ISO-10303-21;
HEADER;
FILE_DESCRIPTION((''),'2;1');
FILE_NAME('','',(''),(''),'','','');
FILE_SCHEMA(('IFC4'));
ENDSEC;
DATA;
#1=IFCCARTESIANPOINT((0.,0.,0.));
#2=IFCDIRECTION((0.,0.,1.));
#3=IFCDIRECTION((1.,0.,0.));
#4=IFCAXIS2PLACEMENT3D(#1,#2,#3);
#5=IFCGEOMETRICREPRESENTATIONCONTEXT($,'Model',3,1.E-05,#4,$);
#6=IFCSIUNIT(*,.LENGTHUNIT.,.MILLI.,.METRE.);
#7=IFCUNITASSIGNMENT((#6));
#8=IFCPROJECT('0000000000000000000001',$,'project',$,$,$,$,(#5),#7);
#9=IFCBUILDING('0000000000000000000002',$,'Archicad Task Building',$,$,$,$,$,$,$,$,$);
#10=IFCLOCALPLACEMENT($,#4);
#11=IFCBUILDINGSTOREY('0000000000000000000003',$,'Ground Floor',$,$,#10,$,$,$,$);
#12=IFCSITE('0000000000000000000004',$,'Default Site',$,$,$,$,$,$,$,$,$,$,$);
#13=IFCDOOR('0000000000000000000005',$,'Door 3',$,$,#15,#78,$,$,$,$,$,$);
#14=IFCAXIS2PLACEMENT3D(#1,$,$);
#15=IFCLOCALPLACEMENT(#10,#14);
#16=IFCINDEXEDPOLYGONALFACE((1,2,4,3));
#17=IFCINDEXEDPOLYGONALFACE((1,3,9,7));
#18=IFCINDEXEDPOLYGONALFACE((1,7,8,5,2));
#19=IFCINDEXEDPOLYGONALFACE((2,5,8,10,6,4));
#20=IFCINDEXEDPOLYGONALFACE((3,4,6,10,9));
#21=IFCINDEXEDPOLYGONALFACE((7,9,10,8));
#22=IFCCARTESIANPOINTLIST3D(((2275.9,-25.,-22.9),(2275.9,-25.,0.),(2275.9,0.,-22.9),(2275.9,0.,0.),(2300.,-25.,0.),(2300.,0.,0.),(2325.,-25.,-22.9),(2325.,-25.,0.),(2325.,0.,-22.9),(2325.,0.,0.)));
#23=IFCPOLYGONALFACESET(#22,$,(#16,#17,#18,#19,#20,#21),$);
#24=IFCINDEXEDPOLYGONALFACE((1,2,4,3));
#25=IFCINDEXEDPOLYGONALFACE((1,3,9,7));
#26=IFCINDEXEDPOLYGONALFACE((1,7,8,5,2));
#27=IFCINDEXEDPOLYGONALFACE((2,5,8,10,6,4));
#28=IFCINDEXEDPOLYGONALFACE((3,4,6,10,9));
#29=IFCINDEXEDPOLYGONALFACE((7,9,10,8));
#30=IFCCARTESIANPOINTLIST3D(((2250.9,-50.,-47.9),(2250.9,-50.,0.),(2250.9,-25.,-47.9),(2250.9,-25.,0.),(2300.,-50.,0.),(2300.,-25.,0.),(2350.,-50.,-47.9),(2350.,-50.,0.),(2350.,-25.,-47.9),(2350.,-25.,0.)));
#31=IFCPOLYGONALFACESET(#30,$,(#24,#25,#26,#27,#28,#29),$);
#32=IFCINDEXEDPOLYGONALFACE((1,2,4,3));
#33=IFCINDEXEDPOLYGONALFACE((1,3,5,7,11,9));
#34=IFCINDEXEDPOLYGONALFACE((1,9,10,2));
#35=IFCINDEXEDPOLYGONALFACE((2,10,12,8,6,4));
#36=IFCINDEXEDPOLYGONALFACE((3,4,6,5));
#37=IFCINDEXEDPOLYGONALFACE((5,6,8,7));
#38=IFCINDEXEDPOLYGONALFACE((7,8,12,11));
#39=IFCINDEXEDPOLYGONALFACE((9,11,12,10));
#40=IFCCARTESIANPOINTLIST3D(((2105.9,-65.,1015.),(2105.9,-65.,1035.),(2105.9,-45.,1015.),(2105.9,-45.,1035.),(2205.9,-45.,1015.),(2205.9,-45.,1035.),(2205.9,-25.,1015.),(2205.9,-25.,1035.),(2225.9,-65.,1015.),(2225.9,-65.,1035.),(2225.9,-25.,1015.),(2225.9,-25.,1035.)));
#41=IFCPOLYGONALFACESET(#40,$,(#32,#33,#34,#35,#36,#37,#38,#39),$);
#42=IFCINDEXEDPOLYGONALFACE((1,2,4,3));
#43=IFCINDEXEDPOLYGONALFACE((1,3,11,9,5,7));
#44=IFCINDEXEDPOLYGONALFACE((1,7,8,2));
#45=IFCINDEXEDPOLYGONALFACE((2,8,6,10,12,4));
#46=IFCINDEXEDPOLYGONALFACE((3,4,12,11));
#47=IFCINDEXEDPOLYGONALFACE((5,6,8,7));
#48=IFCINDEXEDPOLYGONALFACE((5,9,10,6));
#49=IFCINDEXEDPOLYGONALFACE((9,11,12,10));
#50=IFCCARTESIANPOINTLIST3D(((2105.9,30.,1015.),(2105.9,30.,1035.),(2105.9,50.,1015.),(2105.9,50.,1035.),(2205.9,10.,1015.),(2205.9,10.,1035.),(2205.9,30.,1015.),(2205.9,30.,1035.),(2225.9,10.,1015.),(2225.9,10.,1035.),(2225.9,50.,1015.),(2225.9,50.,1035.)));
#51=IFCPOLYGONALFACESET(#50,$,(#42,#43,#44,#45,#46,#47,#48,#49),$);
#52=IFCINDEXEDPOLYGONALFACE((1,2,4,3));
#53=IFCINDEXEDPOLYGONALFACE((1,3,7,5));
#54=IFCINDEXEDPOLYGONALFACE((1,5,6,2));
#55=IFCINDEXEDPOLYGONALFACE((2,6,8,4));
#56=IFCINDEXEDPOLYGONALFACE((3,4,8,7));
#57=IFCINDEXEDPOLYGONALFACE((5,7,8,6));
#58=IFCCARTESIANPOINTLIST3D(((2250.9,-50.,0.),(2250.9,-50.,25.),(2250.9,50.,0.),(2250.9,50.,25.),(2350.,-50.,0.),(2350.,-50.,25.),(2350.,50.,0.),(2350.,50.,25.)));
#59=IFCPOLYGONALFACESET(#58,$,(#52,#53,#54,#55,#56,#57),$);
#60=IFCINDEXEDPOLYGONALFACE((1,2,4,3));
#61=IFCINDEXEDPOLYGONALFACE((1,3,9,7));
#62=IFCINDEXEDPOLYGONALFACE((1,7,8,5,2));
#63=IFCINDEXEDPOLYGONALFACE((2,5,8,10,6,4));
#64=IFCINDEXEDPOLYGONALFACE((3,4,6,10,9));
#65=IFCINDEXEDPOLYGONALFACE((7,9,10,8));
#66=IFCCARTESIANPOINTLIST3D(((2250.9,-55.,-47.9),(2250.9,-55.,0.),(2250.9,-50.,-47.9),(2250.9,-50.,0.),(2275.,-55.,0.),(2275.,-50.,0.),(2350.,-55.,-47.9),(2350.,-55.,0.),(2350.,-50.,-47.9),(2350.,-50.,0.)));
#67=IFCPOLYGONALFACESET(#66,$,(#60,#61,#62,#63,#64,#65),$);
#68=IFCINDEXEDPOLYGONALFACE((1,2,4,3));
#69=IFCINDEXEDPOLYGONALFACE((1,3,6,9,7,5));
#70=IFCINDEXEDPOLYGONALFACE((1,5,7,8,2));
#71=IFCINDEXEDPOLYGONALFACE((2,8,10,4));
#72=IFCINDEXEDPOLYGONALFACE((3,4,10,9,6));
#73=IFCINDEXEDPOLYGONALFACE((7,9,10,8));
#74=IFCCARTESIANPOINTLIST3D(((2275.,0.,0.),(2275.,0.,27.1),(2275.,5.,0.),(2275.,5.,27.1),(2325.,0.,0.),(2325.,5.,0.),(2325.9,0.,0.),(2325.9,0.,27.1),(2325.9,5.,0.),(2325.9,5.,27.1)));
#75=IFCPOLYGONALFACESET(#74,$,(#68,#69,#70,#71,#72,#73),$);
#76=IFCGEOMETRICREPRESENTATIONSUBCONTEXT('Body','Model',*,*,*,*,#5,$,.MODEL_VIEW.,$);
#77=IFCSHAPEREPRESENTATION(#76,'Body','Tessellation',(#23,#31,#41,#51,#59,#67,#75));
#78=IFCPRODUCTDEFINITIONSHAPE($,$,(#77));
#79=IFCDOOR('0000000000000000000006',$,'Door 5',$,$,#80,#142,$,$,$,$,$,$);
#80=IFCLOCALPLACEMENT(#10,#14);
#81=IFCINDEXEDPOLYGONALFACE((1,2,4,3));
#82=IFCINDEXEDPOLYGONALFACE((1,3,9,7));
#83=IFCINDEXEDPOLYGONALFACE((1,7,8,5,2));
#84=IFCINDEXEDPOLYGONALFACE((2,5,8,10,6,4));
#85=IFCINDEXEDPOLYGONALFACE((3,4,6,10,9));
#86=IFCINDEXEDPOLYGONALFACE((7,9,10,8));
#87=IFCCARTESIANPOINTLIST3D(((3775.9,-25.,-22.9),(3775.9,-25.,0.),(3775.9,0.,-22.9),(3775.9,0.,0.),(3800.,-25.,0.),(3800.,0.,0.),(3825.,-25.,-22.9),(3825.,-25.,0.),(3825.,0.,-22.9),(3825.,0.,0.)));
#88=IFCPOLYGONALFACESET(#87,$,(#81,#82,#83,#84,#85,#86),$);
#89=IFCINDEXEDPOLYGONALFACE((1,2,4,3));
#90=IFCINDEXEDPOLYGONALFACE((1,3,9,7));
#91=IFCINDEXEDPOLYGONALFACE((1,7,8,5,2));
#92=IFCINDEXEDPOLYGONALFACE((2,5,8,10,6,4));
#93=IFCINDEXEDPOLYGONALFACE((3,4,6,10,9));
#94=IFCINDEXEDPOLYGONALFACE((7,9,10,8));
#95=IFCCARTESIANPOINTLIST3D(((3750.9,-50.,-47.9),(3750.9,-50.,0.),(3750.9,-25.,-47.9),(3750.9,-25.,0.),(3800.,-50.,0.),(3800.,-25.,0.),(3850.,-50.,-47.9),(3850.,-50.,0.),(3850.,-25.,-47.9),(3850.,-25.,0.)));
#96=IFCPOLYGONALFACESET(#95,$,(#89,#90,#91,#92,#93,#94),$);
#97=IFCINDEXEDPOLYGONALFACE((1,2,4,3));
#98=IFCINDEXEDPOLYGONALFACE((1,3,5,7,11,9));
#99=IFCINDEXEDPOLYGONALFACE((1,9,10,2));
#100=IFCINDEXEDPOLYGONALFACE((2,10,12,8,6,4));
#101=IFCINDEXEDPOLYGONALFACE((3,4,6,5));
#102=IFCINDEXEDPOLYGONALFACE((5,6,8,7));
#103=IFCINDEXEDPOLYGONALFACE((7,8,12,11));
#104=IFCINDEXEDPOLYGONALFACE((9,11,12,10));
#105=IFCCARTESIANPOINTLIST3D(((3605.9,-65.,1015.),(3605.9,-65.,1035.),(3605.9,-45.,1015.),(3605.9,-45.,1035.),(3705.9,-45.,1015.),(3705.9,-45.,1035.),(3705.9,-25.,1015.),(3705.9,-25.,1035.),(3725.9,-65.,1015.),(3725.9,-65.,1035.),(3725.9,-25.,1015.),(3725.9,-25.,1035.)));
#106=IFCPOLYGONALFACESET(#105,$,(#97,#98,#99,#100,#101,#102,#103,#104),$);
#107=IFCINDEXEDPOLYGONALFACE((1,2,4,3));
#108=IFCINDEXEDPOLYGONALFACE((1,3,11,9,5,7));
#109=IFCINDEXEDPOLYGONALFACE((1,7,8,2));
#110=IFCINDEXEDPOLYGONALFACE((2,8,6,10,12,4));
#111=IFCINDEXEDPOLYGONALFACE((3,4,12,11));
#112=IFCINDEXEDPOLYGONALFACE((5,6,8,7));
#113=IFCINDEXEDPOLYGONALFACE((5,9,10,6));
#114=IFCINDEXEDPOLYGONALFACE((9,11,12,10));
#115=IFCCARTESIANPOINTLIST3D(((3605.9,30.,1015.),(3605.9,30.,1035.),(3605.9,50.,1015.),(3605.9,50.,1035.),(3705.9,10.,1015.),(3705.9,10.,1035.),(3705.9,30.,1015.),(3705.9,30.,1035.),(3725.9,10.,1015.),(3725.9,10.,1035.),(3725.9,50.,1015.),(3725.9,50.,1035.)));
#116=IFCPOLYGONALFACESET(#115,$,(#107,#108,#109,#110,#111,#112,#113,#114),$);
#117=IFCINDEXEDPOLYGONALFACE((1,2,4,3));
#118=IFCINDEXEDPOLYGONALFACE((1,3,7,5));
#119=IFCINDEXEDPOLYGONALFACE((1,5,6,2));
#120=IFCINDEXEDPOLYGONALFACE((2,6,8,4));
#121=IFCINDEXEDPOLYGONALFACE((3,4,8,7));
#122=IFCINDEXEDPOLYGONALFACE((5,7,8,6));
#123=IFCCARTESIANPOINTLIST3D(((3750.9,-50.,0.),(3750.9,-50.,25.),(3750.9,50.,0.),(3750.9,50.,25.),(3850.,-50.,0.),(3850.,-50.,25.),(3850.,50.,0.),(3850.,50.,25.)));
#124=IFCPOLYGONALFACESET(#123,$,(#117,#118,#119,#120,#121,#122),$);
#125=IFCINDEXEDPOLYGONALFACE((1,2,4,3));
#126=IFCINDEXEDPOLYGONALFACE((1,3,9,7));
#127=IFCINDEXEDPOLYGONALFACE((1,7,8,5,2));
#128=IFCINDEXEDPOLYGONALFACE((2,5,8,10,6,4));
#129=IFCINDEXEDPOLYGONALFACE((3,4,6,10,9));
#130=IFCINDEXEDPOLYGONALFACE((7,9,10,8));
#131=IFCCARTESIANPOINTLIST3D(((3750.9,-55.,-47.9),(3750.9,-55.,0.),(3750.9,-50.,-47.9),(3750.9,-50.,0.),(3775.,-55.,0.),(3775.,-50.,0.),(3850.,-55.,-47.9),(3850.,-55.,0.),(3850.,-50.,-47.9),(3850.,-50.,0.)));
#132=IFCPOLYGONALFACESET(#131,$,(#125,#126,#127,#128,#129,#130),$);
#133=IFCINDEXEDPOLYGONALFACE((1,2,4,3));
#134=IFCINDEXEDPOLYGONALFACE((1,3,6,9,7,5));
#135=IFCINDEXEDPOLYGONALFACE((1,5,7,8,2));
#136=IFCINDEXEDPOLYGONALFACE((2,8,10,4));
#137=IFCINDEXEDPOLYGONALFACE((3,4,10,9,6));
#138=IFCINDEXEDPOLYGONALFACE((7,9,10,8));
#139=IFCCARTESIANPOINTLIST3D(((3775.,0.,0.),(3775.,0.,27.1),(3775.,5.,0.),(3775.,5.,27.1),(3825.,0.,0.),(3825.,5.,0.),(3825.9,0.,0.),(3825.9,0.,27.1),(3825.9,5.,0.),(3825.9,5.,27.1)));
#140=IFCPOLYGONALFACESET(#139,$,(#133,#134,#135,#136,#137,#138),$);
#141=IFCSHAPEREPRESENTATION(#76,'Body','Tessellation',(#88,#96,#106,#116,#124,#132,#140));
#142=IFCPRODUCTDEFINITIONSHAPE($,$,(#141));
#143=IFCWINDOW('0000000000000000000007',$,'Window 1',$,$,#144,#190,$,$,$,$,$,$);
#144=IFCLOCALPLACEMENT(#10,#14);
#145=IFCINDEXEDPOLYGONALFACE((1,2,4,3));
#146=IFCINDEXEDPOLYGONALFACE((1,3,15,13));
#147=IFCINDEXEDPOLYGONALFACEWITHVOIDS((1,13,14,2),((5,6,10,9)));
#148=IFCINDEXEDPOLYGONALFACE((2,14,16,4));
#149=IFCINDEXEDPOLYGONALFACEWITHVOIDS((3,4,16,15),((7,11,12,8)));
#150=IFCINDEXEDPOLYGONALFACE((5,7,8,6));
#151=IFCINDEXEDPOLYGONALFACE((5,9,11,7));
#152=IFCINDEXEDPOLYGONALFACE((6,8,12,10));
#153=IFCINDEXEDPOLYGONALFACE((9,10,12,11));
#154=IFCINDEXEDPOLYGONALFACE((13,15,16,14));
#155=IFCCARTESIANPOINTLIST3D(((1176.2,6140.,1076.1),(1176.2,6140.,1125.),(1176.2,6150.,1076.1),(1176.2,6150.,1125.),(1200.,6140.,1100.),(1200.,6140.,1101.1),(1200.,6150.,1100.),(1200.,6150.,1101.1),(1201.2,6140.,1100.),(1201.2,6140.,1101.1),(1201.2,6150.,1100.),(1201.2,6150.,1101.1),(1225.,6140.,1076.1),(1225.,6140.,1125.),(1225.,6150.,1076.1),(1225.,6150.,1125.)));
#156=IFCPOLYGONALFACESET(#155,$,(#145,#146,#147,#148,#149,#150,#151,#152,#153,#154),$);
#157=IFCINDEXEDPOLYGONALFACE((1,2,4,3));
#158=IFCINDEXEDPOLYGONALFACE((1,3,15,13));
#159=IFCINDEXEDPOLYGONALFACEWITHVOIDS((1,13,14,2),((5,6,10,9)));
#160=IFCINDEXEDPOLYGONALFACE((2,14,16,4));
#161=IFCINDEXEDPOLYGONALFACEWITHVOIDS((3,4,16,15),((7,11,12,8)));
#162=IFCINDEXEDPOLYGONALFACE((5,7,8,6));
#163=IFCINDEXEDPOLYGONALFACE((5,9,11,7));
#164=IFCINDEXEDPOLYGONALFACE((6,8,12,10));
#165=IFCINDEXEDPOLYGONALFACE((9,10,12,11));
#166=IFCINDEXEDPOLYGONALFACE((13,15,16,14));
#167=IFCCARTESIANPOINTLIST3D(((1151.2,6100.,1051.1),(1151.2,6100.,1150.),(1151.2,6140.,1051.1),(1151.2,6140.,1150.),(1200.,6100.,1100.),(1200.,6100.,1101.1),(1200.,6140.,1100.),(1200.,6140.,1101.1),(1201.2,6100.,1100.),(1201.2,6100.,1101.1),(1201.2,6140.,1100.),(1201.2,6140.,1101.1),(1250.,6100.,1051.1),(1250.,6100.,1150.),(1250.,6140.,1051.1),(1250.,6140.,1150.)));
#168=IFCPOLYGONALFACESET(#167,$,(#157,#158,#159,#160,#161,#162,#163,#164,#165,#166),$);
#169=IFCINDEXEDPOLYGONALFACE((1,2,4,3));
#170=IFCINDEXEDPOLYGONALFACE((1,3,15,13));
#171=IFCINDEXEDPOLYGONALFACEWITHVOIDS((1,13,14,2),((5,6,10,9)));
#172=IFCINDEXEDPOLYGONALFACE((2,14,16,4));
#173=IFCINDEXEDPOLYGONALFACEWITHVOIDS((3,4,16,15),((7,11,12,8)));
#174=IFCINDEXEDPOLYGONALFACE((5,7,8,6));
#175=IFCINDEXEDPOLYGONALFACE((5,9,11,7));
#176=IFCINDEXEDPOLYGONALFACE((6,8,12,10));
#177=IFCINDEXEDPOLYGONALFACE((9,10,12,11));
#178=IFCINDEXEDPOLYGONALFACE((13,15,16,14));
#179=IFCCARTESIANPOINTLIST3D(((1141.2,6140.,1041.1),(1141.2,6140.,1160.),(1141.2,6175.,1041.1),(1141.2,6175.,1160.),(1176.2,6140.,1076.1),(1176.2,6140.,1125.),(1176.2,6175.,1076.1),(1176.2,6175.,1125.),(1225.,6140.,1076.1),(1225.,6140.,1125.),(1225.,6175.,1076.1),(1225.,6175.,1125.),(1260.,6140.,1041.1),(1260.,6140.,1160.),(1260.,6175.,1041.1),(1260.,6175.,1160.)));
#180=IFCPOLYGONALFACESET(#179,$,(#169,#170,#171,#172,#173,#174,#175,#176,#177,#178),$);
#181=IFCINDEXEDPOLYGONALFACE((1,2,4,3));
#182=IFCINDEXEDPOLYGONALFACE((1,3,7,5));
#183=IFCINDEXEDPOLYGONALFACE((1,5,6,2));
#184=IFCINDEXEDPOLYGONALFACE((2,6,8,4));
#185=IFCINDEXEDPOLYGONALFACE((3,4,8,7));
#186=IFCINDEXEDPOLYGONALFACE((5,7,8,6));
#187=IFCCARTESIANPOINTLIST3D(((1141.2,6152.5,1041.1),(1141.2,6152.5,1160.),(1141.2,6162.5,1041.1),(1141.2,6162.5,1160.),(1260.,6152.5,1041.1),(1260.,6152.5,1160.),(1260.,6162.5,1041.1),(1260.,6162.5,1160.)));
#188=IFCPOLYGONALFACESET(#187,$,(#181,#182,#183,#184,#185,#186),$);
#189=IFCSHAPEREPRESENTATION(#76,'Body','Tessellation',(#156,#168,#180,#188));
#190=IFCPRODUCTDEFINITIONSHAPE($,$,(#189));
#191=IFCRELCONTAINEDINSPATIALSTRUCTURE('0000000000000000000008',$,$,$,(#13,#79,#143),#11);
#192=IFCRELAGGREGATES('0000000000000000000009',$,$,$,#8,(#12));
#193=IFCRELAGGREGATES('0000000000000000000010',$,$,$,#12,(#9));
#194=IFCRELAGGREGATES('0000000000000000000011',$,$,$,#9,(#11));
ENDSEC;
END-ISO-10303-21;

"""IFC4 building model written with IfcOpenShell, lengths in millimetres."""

from ifc_helpers import new_model, si_unit, frame, origin_with_axes, place, context, subcontext, project, spatial, line, indexed_curve, outline, extrude, element, save


model = new_model("IFC4")

# Units and contexts
model_context = context("Model", 3, precision=1e-05, world=origin_with_axes())
body_context = subcontext(model_context, "Body", "Model", "MODEL_VIEW")
ifc_project = project(units=[si_unit("LENGTHUNIT", "METRE", prefix="MILLI")], contexts=[model_context])

# Site, building, storey
site = spatial("IfcSite", under=ifc_project, Name="Default Site")
building = spatial("IfcBuilding", under=site, Name="Archicad Task Building")
storey_placement = place(None, origin_with_axes())
storey = spatial("IfcBuildingStorey", under=building, at=storey_placement, Name="Ground Floor")

# Doors
door_1_placement = place(storey_placement, frame((2300.0, -50.0, 0.0), z_axis=(0.0, 0.0, 1.0), x_axis=(1.0, 0.0, 0.0)))
element("IfcDoor", 1, at=door_1_placement, inside=storey, Name="Door 3", context=body_context, shape_type="SweptSolid", body=[
    extrude(outline(indexed_curve([(0.0, 0.0), (0.0, 2.1), (0.9, 2.1), (0.9, 0.0), (-24.1, 0.0), (-24.1, -22.9), (25.0, -22.9), (25.0, 0.0)], segments=[line(1, 2, 3, 4, 5, 6, 7, 8, 1)])), frame((0.0, 25.0, 0.0), z_axis=(0.0, -1.0, 0.0), x_axis=(1.0, 0.0, 0.0)), (0.0, 0.0, -1.0), 25.0),
    extrude(outline(indexed_curve([(0.0, 0.0), (0.0, 2.1), (0.9, 2.1), (0.9, 0.0), (-49.1, 0.0), (-49.1, -47.9), (50.0, -47.9), (50.0, 0.0)], segments=[line(1, 2, 3, 4, 5, 6, 7, 8, 1)])), frame((0.0, 0.0, 0.0), z_axis=(0.0, -1.0, 0.0), x_axis=(1.0, 0.0, 0.0)), (0.0, 0.0, -1.0), 25.0),
    extrude(outline(indexed_curve([(0.0, 0.0), (-49.1, 0.0), (-49.1, 35.0), (0.0, 35.0)], segments=[line(1, 2, 3, 4, 1)])), frame((25.0, 25.0, 25.0), z_axis=(0.0, 0.0, 1.0), x_axis=(1.0, 0.0, 0.0)), (0.0, 0.0, 1.0), -47.9),
    extrude(outline(indexed_curve([(0.0, 0.0), (0.0, -40.0), (-120.0, -40.0), (-120.0, -20.0), (-20.0, -20.0), (-20.0, 0.0)], segments=[line(1, 2, 3, 4, 5, 6, 1)])), frame((-74.1, 25.0, 1015.0), z_axis=(0.0, 0.0, 1.0), x_axis=(1.0, 0.0, 0.0)), (0.0, 0.0, 1.0), 20.0),
    extrude(outline(indexed_curve([(0.0, 0.0), (0.0, 40.0), (-120.0, 40.0), (-120.0, 20.0), (-20.0, 20.0), (-20.0, 0.0)], segments=[line(1, 2, 3, 4, 5, 6, 1)])), frame((-74.1, 60.0, 1015.0), z_axis=(0.0, 0.0, 1.0), x_axis=(1.0, 0.0, 0.0)), (0.0, 0.0, 1.0), 20.0),
    extrude(outline(indexed_curve([(0.0, 0.0), (-99.1, 0.0), (-99.1, 100.0), (0.0, 100.0)], segments=[line(1, 2, 3, 4, 1)])), frame((50.0, 0.0, 0.0), z_axis=(0.0, 0.0, 1.0), x_axis=(1.0, 0.0, 0.0)), (0.0, 0.0, 1.0), 25.0),
    extrude(outline(indexed_curve([(0.0, 0.0), (0.0, 27.1), (50.9, 27.1), (50.9, 0.0), (-24.1, 0.0), (-24.1, -47.9), (75.0, -47.9), (75.0, 0.0)], segments=[line(1, 2, 3, 4, 5, 6, 7, 8, 1)])), frame((-25.0, -5.0, 0.0), z_axis=(0.0, -1.0, 0.0), x_axis=(1.0, 0.0, 0.0)), (0.0, 0.0, -1.0), 5.0),
    extrude(outline(indexed_curve([(0.0, 0.0), (0.0, 27.1), (50.9, 27.1), (50.9, 0.0), (0.9, 0.0), (0.9, -22.9), (50.0, -22.9), (50.0, 0.0)], segments=[line(1, 2, 3, 4, 5, 6, 7, 8, 1)])), frame((-25.0, 50.0, 0.0), z_axis=(0.0, -1.0, 0.0), x_axis=(1.0, 0.0, 0.0)), (0.0, 0.0, -1.0), 5.0),
])
door_2_placement = place(storey_placement, frame((3800.0, -50.0, 0.0), z_axis=(0.0, 0.0, 1.0), x_axis=(1.0, 0.0, 0.0)))
element("IfcDoor", 2, at=door_2_placement, inside=storey, Name="Door 5", context=body_context, shape_type="SweptSolid", body=[
    extrude(outline(indexed_curve([(0.0, 0.0), (0.0, 2.1), (0.9, 2.1), (0.9, 0.0), (-24.1, 0.0), (-24.1, -22.9), (25.0, -22.9), (25.0, 0.0)], segments=[line(1, 2, 3, 4, 5, 6, 7, 8, 1)])), frame((0.0, 25.0, 0.0), z_axis=(0.0, -1.0, 0.0), x_axis=(1.0, 0.0, 0.0)), (0.0, 0.0, -1.0), 25.0),
    extrude(outline(indexed_curve([(0.0, 0.0), (0.0, 2.1), (0.9, 2.1), (0.9, 0.0), (-49.1, 0.0), (-49.1, -47.9), (50.0, -47.9), (50.0, 0.0)], segments=[line(1, 2, 3, 4, 5, 6, 7, 8, 1)])), frame((0.0, 0.0, 0.0), z_axis=(0.0, -1.0, 0.0), x_axis=(1.0, 0.0, 0.0)), (0.0, 0.0, -1.0), 25.0),
    extrude(outline(indexed_curve([(0.0, 0.0), (-49.1, 0.0), (-49.1, 35.0), (0.0, 35.0)], segments=[line(1, 2, 3, 4, 1)])), frame((25.0, 25.0, 25.0), z_axis=(0.0, 0.0, 1.0), x_axis=(1.0, 0.0, 0.0)), (0.0, 0.0, 1.0), -47.9),
    extrude(outline(indexed_curve([(0.0, 0.0), (0.0, -40.0), (-120.0, -40.0), (-120.0, -20.0), (-20.0, -20.0), (-20.0, 0.0)], segments=[line(1, 2, 3, 4, 5, 6, 1)])), frame((-74.1, 25.0, 1015.0), z_axis=(0.0, 0.0, 1.0), x_axis=(1.0, 0.0, 0.0)), (0.0, 0.0, 1.0), 20.0),
    extrude(outline(indexed_curve([(0.0, 0.0), (0.0, 40.0), (-120.0, 40.0), (-120.0, 20.0), (-20.0, 20.0), (-20.0, 0.0)], segments=[line(1, 2, 3, 4, 5, 6, 1)])), frame((-74.1, 60.0, 1015.0), z_axis=(0.0, 0.0, 1.0), x_axis=(1.0, 0.0, 0.0)), (0.0, 0.0, 1.0), 20.0),
    extrude(outline(indexed_curve([(0.0, 0.0), (-99.1, 0.0), (-99.1, 100.0), (0.0, 100.0)], segments=[line(1, 2, 3, 4, 1)])), frame((50.0, 0.0, 0.0), z_axis=(0.0, 0.0, 1.0), x_axis=(1.0, 0.0, 0.0)), (0.0, 0.0, 1.0), 25.0),
    extrude(outline(indexed_curve([(0.0, 0.0), (0.0, 27.1), (50.9, 27.1), (50.9, 0.0), (-24.1, 0.0), (-24.1, -47.9), (75.0, -47.9), (75.0, 0.0)], segments=[line(1, 2, 3, 4, 5, 6, 7, 8, 1)])), frame((-25.0, -5.0, 0.0), z_axis=(0.0, -1.0, 0.0), x_axis=(1.0, 0.0, 0.0)), (0.0, 0.0, -1.0), 5.0),
    extrude(outline(indexed_curve([(0.0, 0.0), (0.0, 27.1), (50.9, 27.1), (50.9, 0.0), (0.9, 0.0), (0.9, -22.9), (50.0, -22.9), (50.0, 0.0)], segments=[line(1, 2, 3, 4, 5, 6, 7, 8, 1)])), frame((-25.0, 50.0, 0.0), z_axis=(0.0, -1.0, 0.0), x_axis=(1.0, 0.0, 0.0)), (0.0, 0.0, -1.0), 5.0),
])

# Window
for number, where, z_axis, x_axis, name in (
    (3, (1200.0, 6050.0, 1100.0), (0.0, 0.0, 1.0), (1.0, 0.0, 0.0), "Window 1"),
):
    element("IfcWindow", number, at=place(storey_placement, frame(where, z_axis=z_axis, x_axis=x_axis)), inside=storey, Name=name, context=body_context, shape_type="SweptSolid", body=[
        extrude(outline(indexed_curve([(0.0, 0.0), (1.2, 0.0), (1.2, 1.1), (0.0, 1.1)], segments=[line(1, 2, 3, 4, 1)]), holes=[indexed_curve([(25.0, 25.0), (-23.8, 25.0), (-23.8, -23.9), (25.0, -23.9)], segments=[line(1, 2, 3, 4, 1)])]), frame((0.0, 90.0, 0.0), z_axis=(0.0, -1.0, 0.0), x_axis=(1.0, 0.0, 0.0)), (0.0, 0.0, -1.0), 10.0),
        extrude(outline(indexed_curve([(0.0, 0.0), (1.2, 0.0), (1.2, 1.1), (0.0, 1.1)], segments=[line(1, 2, 3, 4, 1)]), holes=[indexed_curve([(50.0, 50.0), (-48.8, 50.0), (-48.8, -48.9), (50.0, -48.9)], segments=[line(1, 2, 3, 4, 1)])]), frame((0.0, 50.0, 0.0), z_axis=(0.0, -1.0, 0.0), x_axis=(1.0, 0.0, 0.0)), (0.0, 0.0, -1.0), 40.0),
        extrude(outline(indexed_curve([(0.0, 0.0), (-48.8, 0.0), (-48.8, -48.9), (0.0, -48.9)], segments=[line(1, 2, 3, 4, 1)]), holes=[indexed_curve([(35.0, 35.0), (-83.8, 35.0), (-83.8, -83.9), (35.0, -83.9)], segments=[line(1, 2, 3, 4, 1)])]), frame((25.0, 90.0, 25.0), z_axis=(0.0, -1.0, 0.0), x_axis=(1.0, 0.0, 0.0)), (0.0, 0.0, -1.0), 35.0),
        extrude(outline(indexed_curve([(35.0, 35.0), (-83.8, 35.0), (-83.8, -83.9), (35.0, -83.9)], segments=[line(1, 2, 3, 4, 1)])), frame((25.0, 102.5, 25.0), z_axis=(0.0, -1.0, 0.0), x_axis=(1.0, 0.0, 0.0)), (0.0, 0.0, -1.0), 10.0),
    ])

save(model, "model.ifc")
